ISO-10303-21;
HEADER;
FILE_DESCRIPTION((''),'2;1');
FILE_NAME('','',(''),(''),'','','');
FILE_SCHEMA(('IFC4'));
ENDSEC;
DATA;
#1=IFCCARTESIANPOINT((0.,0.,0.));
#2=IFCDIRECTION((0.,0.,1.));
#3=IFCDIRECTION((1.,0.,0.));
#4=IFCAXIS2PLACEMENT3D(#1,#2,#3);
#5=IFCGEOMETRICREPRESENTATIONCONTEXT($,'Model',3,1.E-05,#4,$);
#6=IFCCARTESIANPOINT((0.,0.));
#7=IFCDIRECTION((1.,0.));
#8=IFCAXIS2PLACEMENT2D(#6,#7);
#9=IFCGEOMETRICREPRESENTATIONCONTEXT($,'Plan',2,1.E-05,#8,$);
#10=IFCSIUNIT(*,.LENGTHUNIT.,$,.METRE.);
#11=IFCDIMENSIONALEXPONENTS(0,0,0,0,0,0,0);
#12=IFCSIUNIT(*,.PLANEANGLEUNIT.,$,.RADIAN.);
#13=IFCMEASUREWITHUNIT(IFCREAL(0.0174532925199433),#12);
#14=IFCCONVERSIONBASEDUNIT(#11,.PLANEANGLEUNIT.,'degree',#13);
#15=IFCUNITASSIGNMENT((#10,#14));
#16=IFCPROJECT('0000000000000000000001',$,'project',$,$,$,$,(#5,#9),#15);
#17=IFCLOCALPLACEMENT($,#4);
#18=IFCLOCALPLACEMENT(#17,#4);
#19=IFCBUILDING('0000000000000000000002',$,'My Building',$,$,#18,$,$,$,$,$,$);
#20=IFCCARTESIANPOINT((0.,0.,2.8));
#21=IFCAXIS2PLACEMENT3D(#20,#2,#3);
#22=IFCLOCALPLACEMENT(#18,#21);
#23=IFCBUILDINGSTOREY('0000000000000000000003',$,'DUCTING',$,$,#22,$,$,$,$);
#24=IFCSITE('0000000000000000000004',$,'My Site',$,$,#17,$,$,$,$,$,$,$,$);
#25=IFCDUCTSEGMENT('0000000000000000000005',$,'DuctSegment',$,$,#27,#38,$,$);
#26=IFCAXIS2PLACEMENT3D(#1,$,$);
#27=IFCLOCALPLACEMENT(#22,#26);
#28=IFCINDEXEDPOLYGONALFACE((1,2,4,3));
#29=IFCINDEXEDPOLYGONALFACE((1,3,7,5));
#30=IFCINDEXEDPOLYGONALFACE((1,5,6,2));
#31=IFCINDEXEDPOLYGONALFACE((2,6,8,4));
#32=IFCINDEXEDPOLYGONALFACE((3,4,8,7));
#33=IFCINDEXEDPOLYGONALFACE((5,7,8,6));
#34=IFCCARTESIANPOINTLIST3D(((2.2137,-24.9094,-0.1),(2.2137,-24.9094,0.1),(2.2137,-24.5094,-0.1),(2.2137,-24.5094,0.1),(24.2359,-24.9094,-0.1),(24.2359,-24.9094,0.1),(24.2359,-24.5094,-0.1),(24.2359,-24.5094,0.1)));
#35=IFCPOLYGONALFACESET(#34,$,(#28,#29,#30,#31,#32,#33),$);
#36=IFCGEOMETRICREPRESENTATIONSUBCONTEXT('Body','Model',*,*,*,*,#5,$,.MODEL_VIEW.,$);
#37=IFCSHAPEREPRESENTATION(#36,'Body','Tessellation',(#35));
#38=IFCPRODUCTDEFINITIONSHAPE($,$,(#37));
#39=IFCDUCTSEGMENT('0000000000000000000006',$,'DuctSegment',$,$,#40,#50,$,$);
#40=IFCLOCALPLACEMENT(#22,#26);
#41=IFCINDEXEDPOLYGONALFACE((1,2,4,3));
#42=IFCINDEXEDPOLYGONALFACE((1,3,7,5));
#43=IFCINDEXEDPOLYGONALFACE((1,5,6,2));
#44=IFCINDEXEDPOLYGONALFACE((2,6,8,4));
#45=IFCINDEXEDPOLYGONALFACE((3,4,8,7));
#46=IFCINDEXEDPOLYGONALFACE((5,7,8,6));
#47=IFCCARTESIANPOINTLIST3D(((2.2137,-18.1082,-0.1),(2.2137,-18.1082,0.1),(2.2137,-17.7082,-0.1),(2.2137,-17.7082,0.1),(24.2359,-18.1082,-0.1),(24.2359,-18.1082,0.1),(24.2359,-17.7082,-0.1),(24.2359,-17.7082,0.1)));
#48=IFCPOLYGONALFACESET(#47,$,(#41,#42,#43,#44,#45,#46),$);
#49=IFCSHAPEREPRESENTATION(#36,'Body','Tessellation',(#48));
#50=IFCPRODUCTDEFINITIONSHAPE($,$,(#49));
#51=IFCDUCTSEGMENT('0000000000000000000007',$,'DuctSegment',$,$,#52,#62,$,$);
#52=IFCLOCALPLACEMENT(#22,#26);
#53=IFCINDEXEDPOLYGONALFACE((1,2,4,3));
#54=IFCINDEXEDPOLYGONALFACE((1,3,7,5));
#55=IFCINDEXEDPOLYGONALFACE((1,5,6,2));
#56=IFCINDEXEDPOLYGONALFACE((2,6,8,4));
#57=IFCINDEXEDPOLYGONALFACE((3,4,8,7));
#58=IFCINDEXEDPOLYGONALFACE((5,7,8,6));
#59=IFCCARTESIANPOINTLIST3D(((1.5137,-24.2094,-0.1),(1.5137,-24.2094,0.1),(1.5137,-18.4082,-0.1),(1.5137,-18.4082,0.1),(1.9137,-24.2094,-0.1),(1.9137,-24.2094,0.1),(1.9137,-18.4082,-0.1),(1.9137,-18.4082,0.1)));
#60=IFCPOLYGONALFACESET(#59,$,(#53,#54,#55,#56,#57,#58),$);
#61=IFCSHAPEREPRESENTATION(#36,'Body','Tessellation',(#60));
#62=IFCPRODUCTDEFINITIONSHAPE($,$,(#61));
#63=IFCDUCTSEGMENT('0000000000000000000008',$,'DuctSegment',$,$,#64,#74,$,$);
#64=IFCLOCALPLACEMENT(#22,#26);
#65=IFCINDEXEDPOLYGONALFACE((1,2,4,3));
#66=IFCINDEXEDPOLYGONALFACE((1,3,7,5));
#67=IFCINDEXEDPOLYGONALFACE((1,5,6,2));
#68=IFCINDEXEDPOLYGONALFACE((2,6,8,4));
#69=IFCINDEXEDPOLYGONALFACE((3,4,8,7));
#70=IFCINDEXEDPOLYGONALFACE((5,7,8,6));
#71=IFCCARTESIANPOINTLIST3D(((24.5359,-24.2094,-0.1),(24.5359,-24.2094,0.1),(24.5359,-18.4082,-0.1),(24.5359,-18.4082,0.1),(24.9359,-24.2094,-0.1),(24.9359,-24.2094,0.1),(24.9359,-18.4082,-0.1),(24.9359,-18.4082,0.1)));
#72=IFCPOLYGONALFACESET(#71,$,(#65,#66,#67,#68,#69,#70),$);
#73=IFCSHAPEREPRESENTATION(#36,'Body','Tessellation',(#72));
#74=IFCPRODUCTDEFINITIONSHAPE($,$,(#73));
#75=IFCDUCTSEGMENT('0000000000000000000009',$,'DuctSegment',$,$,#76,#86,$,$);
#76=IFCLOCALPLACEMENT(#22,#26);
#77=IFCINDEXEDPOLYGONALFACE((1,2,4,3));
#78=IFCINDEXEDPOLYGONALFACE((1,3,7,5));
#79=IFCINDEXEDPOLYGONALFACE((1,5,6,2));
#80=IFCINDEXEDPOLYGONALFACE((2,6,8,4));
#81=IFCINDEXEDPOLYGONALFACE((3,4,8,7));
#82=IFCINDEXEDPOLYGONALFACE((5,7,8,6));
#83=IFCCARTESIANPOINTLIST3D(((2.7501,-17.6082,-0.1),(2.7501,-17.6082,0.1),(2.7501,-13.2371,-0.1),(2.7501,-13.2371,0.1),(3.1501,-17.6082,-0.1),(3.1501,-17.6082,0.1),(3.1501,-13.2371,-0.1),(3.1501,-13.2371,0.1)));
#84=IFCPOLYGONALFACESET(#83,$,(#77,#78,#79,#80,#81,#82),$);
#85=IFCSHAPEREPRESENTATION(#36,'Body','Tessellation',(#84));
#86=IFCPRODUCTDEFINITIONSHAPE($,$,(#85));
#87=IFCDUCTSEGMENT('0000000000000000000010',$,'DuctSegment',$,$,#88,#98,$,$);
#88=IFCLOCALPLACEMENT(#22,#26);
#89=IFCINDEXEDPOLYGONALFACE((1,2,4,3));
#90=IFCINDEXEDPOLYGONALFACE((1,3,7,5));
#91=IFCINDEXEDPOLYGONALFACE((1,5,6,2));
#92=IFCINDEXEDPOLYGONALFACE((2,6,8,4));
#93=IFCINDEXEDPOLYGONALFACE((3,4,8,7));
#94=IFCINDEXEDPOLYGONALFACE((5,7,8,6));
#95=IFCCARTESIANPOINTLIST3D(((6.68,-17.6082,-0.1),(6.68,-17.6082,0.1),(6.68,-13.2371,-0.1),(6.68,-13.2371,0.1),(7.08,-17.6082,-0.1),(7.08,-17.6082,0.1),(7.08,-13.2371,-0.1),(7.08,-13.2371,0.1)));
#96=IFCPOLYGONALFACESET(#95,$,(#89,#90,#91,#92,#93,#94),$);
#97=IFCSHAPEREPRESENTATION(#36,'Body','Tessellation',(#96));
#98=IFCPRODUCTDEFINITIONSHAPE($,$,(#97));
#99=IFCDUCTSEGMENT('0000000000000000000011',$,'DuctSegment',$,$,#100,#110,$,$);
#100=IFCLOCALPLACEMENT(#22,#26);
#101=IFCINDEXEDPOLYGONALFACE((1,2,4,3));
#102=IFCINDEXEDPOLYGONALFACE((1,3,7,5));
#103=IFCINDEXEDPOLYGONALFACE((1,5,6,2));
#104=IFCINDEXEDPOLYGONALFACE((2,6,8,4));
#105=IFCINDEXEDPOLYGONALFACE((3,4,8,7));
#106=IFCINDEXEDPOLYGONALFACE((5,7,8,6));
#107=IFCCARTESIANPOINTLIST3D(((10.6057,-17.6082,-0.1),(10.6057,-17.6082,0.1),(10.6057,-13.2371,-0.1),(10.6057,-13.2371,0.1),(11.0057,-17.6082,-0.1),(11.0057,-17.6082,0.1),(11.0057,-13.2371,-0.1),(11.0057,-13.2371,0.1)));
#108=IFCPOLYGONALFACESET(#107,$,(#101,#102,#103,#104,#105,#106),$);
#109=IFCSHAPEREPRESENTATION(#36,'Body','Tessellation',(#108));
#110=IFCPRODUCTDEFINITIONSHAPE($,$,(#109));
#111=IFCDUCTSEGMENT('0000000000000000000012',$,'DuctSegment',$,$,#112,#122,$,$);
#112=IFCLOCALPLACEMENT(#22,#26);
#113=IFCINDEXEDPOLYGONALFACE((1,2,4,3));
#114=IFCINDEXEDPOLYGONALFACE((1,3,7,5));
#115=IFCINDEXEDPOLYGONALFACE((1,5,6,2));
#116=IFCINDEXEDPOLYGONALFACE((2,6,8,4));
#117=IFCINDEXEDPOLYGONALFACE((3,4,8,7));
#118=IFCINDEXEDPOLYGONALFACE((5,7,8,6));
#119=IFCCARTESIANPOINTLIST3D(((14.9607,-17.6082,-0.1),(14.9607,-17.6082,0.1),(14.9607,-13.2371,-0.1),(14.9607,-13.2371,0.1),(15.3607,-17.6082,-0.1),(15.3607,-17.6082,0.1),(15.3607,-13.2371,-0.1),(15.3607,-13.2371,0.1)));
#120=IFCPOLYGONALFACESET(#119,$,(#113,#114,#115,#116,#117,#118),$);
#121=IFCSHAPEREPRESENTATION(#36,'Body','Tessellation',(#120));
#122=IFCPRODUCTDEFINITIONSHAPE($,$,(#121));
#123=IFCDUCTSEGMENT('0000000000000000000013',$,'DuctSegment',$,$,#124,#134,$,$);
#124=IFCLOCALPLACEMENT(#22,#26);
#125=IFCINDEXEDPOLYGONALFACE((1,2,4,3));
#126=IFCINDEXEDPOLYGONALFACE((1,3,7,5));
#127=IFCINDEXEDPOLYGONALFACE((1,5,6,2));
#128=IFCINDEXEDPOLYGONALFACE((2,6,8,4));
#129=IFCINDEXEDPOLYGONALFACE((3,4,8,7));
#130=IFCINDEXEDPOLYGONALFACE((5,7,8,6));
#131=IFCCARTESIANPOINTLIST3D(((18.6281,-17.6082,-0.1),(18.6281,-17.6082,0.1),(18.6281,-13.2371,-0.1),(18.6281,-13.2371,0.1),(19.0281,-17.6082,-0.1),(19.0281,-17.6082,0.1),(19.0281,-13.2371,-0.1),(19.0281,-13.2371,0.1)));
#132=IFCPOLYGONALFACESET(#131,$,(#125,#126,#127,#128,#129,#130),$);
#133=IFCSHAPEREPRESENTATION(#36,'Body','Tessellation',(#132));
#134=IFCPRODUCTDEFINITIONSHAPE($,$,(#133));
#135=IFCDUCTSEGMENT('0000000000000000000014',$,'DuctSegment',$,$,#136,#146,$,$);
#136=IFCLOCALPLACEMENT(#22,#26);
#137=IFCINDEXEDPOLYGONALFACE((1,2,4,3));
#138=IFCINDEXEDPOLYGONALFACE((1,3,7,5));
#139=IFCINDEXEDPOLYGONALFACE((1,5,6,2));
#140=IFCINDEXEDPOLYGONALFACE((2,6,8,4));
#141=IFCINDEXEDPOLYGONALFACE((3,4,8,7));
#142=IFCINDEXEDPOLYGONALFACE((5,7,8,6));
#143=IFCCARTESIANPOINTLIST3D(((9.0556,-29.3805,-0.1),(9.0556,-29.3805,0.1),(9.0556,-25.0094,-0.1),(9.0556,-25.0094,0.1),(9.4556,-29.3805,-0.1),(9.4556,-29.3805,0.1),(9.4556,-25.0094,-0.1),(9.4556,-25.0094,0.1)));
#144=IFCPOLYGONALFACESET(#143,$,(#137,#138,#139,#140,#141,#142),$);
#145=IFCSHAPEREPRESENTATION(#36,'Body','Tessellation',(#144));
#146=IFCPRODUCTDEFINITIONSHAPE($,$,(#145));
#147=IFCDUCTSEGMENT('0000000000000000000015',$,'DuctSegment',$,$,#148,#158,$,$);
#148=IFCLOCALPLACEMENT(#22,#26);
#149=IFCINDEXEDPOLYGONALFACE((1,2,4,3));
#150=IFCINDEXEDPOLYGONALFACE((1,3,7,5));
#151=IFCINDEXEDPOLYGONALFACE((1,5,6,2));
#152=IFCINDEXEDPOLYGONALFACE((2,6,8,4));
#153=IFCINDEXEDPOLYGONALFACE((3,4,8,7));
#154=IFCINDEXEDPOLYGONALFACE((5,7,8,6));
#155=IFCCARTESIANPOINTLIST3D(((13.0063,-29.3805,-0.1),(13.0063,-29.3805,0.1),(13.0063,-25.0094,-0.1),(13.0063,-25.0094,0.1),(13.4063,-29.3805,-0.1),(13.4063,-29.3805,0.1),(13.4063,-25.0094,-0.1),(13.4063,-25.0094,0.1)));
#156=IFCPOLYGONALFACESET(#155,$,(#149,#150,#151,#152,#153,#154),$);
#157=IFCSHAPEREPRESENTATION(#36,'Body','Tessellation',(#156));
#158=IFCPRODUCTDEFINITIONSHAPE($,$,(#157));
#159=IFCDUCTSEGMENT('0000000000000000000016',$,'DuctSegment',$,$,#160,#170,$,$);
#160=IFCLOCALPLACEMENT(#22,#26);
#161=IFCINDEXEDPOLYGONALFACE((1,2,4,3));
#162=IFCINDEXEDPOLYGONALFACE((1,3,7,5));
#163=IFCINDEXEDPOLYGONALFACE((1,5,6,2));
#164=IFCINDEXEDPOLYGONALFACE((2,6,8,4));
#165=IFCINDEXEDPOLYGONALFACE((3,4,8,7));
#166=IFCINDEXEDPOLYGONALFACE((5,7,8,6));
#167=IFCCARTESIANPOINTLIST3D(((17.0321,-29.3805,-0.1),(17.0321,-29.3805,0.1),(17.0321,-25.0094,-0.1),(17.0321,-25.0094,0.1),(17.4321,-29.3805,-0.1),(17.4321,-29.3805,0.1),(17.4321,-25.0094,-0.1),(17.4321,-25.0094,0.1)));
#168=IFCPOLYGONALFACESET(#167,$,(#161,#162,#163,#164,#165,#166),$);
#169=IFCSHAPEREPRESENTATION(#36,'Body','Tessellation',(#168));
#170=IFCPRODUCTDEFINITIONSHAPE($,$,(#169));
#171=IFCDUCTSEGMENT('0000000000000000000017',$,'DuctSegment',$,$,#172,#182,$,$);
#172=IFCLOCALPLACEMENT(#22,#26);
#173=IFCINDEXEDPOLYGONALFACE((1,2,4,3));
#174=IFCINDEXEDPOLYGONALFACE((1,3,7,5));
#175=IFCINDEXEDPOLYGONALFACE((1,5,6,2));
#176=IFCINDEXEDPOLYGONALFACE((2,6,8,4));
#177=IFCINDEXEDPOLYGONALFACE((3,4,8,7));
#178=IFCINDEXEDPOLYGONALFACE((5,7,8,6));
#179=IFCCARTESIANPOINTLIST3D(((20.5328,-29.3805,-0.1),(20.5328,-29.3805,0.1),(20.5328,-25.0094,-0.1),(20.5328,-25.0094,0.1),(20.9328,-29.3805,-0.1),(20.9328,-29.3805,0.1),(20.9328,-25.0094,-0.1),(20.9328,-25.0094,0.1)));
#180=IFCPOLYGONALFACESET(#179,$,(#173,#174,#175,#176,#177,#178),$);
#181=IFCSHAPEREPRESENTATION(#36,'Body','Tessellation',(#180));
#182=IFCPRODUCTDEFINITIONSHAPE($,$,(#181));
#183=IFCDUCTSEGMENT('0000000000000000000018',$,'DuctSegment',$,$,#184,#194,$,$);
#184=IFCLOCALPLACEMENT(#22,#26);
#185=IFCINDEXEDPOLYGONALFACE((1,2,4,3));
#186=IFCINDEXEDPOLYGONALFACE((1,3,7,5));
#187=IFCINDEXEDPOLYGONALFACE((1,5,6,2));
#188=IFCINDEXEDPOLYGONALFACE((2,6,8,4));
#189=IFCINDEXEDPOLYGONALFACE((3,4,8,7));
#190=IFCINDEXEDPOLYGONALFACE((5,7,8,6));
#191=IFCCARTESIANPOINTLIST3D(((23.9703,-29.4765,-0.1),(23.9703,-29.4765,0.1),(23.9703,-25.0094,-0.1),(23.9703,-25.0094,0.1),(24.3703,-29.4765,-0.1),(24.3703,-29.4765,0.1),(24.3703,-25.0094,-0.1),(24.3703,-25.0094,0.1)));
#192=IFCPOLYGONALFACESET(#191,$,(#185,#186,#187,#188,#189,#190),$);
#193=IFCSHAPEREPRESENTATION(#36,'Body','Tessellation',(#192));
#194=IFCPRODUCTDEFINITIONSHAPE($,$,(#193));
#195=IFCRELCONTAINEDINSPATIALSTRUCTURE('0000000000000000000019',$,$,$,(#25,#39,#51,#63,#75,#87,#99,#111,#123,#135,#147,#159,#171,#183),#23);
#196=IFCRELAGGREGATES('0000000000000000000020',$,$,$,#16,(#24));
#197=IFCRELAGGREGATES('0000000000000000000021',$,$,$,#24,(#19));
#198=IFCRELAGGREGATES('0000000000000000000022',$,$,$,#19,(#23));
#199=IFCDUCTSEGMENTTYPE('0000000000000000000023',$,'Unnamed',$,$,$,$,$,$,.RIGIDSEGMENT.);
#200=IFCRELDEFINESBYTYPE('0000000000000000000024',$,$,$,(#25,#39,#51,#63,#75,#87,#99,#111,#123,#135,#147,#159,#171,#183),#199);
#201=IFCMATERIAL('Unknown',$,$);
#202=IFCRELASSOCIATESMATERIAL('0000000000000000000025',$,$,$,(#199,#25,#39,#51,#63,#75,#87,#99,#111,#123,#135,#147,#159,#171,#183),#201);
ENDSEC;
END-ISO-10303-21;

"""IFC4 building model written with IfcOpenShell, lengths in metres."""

from ifc_helpers import new_model, entity, si_unit, converted_unit, frame, origin_with_axes, origin_2d_with_axis, place, context, subcontext, project, spatial, rectangle, extrude, material, material_profile, profile_set, profile_usage, type_object, element, save


model = new_model("IFC4")

# Units and contexts
model_context = context("Model", 3, precision=1e-05, world=origin_with_axes())
plan_context = context("Plan", 2, precision=1e-05, world=origin_2d_with_axis())
body_context = subcontext(model_context, "Body", "Model", "MODEL_VIEW")
ifc_project = project(units=[si_unit("LENGTHUNIT", "METRE"), converted_unit("PLANEANGLEUNIT", "degree", entity("IfcReal", 0.0174532925199433), si_unit("PLANEANGLEUNIT", "RADIAN"), dimensions=[0, 0, 0, 0, 0, 0, 0])], contexts=[model_context, plan_context])

# Site, building, storey
site_placement = place(None, origin_with_axes())
site = spatial("IfcSite", under=ifc_project, at=site_placement, Name="My Site")
building_placement = place(site_placement, origin_with_axes())
building = spatial("IfcBuilding", under=site, at=building_placement, Name="My Building")
storey_placement = place(building_placement, frame((0.0, 0.0, 2.8), z_axis=(0.0, 0.0, 1.0), x_axis=(1.0, 0.0, 0.0)))
storey = spatial("IfcBuildingStorey", under=building, at=storey_placement, Name="DUCTING")

# Duct segments
ifc_material = material(Name="Unknown")
ifc_material_profile = material_profile(ifc_material, rectangle(XDim=0.4, YDim=0.2))
ifc_profile_set = profile_set([ifc_material_profile])
ifc_profile_usage_1 = profile_usage(ifc_profile_set, cardinal=5)
duct_segment_type = type_object("IfcDuctSegmentType", Name="Unnamed", PredefinedType="RIGIDSEGMENT", material=ifc_profile_set)
duct_segment_1_placement = place(storey_placement, frame((2.2137, -24.7094, 0.0), z_axis=(1.0, 0.0, 0.0), x_axis=(0.0, 1.0, 0.0)))
element("IfcDuctSegment", 1, at=duct_segment_1_placement, inside=storey, type_object=duct_segment_type, material=ifc_profile_usage_1, Name="DuctSegment", context=body_context, shape_type="SweptSolid", body=[
    extrude(rectangle(XDim=0.4, YDim=0.2), origin_with_axes(), (0.0, 0.0, 1.0), 22.0221),
])
ifc_profile_usage_2 = profile_usage(ifc_profile_set, cardinal=5)
duct_segment_2_placement = place(storey_placement, frame((2.2137, -17.9082, 0.0), z_axis=(1.0, 0.0, 0.0), x_axis=(0.0, 1.0, 0.0)))
element("IfcDuctSegment", 2, at=duct_segment_2_placement, inside=storey, type_object=duct_segment_type, material=ifc_profile_usage_2, Name="DuctSegment", context=body_context, shape_type="SweptSolid", body=[
    extrude(rectangle(XDim=0.4, YDim=0.2), origin_with_axes(), (0.0, 0.0, 1.0), 22.0221),
])
ifc_profile_usage_3 = profile_usage(ifc_profile_set, cardinal=5)
duct_segment_3_placement = place(storey_placement, frame((1.7137, -24.2094, 0.0), z_axis=(0.0, 1.0, 0.0), x_axis=(1.0, 0.0, 0.0)))
element("IfcDuctSegment", 3, at=duct_segment_3_placement, inside=storey, type_object=duct_segment_type, material=ifc_profile_usage_3, Name="DuctSegment", context=body_context, shape_type="SweptSolid", body=[
    extrude(rectangle(XDim=0.4, YDim=0.2), origin_with_axes(), (0.0, 0.0, 1.0), 5.8013),
])
ifc_profile_usage_4 = profile_usage(ifc_profile_set, cardinal=5)
duct_segment_4_placement = place(storey_placement, frame((24.7359, -24.2094, 0.0), z_axis=(0.0, 1.0, 0.0), x_axis=(1.0, 0.0, 0.0)))
element("IfcDuctSegment", 4, at=duct_segment_4_placement, inside=storey, type_object=duct_segment_type, material=ifc_profile_usage_4, Name="DuctSegment", context=body_context, shape_type="SweptSolid", body=[
    extrude(rectangle(XDim=0.4, YDim=0.2), origin_with_axes(), (0.0, 0.0, 1.0), 5.8013),
])
ifc_profile_usage_5 = profile_usage(ifc_profile_set, cardinal=5)
duct_segment_5_placement = place(storey_placement, frame((2.9501, -13.2371, 0.0), z_axis=(0.0, -1.0, 0.0), x_axis=(1.0, 0.0, 0.0)))
element("IfcDuctSegment", 5, at=duct_segment_5_placement, inside=storey, type_object=duct_segment_type, material=ifc_profile_usage_5, Name="DuctSegment", context=body_context, shape_type="SweptSolid", body=[
    extrude(rectangle(XDim=0.4, YDim=0.2), origin_with_axes(), (0.0, 0.0, 1.0), 4.3711),
])
ifc_profile_usage_6 = profile_usage(ifc_profile_set, cardinal=5)
duct_segment_6_placement = place(storey_placement, frame((6.88, -13.2371, 0.0), z_axis=(0.0, -1.0, 0.0), x_axis=(1.0, 0.0, 0.0)))
element("IfcDuctSegment", 6, at=duct_segment_6_placement, inside=storey, type_object=duct_segment_type, material=ifc_profile_usage_6, Name="DuctSegment", context=body_context, shape_type="SweptSolid", body=[
    extrude(rectangle(XDim=0.4, YDim=0.2), origin_with_axes(), (0.0, 0.0, 1.0), 4.3711),
])
ifc_profile_usage_7 = profile_usage(ifc_profile_set, cardinal=5)
duct_segment_7_placement = place(storey_placement, frame((10.8057, -13.2371, 0.0), z_axis=(0.0, -1.0, 0.0), x_axis=(1.0, 0.0, 0.0)))
element("IfcDuctSegment", 7, at=duct_segment_7_placement, inside=storey, type_object=duct_segment_type, material=ifc_profile_usage_7, Name="DuctSegment", context=body_context, shape_type="SweptSolid", body=[
    extrude(rectangle(XDim=0.4, YDim=0.2), origin_with_axes(), (0.0, 0.0, 1.0), 4.3711),
])
ifc_profile_usage_8 = profile_usage(ifc_profile_set, cardinal=5)
duct_segment_8_placement = place(storey_placement, frame((15.1607, -13.2371, 0.0), z_axis=(0.0, -1.0, 0.0), x_axis=(1.0, 0.0, 0.0)))
element("IfcDuctSegment", 8, at=duct_segment_8_placement, inside=storey, type_object=duct_segment_type, material=ifc_profile_usage_8, Name="DuctSegment", context=body_context, shape_type="SweptSolid", body=[
    extrude(rectangle(XDim=0.4, YDim=0.2), origin_with_axes(), (0.0, 0.0, 1.0), 4.3711),
])
ifc_profile_usage_9 = profile_usage(ifc_profile_set, cardinal=5)
duct_segment_9_placement = place(storey_placement, frame((18.8281, -13.2371, 0.0), z_axis=(0.0, -1.0, 0.0), x_axis=(1.0, 0.0, 0.0)))
element("IfcDuctSegment", 9, at=duct_segment_9_placement, inside=storey, type_object=duct_segment_type, material=ifc_profile_usage_9, Name="DuctSegment", context=body_context, shape_type="SweptSolid", body=[
    extrude(rectangle(XDim=0.4, YDim=0.2), origin_with_axes(), (0.0, 0.0, 1.0), 4.3711),
])
ifc_profile_usage_10 = profile_usage(ifc_profile_set, cardinal=5)
duct_segment_10_placement = place(storey_placement, frame((9.2556, -29.3805, 0.0), z_axis=(0.0, 1.0, 0.0), x_axis=(-1.0, 0.0, 0.0)))
element("IfcDuctSegment", 10, at=duct_segment_10_placement, inside=storey, type_object=duct_segment_type, material=ifc_profile_usage_10, Name="DuctSegment", context=body_context, shape_type="SweptSolid", body=[
    extrude(rectangle(XDim=0.4, YDim=0.2), origin_with_axes(), (0.0, 0.0, 1.0), 4.3711),
])
ifc_profile_usage_11 = profile_usage(ifc_profile_set, cardinal=5)
duct_segment_11_placement = place(storey_placement, frame((13.2063, -29.3805, 0.0), z_axis=(0.0, 1.0, 0.0), x_axis=(-1.0, 0.0, 0.0)))
element("IfcDuctSegment", 11, at=duct_segment_11_placement, inside=storey, type_object=duct_segment_type, material=ifc_profile_usage_11, Name="DuctSegment", context=body_context, shape_type="SweptSolid", body=[
    extrude(rectangle(XDim=0.4, YDim=0.2), origin_with_axes(), (0.0, 0.0, 1.0), 4.3711),
])
ifc_profile_usage_12 = profile_usage(ifc_profile_set, cardinal=5)
duct_segment_12_placement = place(storey_placement, frame((17.2321, -29.3805, 0.0), z_axis=(0.0, 1.0, 0.0), x_axis=(-1.0, 0.0, 0.0)))
element("IfcDuctSegment", 12, at=duct_segment_12_placement, inside=storey, type_object=duct_segment_type, material=ifc_profile_usage_12, Name="DuctSegment", context=body_context, shape_type="SweptSolid", body=[
    extrude(rectangle(XDim=0.4, YDim=0.2), origin_with_axes(), (0.0, 0.0, 1.0), 4.3711),
])
ifc_profile_usage_13 = profile_usage(ifc_profile_set, cardinal=5)
duct_segment_13_placement = place(storey_placement, frame((20.7328, -29.3805, 0.0), z_axis=(0.0, 1.0, 0.0), x_axis=(-1.0, 0.0, 0.0)))
element("IfcDuctSegment", 13, at=duct_segment_13_placement, inside=storey, type_object=duct_segment_type, material=ifc_profile_usage_13, Name="DuctSegment", context=body_context, shape_type="SweptSolid", body=[
    extrude(rectangle(XDim=0.4, YDim=0.2), origin_with_axes(), (0.0, 0.0, 1.0), 4.3711),
])
ifc_profile_usage_14 = profile_usage(ifc_profile_set, cardinal=5)
duct_segment_14_placement = place(storey_placement, frame((24.1703, -25.0094, 0.0), z_axis=(0.0, -1.0, 0.0), x_axis=(1.0, 0.0, 0.0)))
element("IfcDuctSegment", 14, at=duct_segment_14_placement, inside=storey, type_object=duct_segment_type, material=ifc_profile_usage_14, Name="DuctSegment", context=body_context, shape_type="SweptSolid", body=[
    extrude(rectangle(XDim=0.4, YDim=0.2), origin_with_axes(), (0.0, 0.0, 1.0), 4.4671),
])

save(model, "model.ifc")
